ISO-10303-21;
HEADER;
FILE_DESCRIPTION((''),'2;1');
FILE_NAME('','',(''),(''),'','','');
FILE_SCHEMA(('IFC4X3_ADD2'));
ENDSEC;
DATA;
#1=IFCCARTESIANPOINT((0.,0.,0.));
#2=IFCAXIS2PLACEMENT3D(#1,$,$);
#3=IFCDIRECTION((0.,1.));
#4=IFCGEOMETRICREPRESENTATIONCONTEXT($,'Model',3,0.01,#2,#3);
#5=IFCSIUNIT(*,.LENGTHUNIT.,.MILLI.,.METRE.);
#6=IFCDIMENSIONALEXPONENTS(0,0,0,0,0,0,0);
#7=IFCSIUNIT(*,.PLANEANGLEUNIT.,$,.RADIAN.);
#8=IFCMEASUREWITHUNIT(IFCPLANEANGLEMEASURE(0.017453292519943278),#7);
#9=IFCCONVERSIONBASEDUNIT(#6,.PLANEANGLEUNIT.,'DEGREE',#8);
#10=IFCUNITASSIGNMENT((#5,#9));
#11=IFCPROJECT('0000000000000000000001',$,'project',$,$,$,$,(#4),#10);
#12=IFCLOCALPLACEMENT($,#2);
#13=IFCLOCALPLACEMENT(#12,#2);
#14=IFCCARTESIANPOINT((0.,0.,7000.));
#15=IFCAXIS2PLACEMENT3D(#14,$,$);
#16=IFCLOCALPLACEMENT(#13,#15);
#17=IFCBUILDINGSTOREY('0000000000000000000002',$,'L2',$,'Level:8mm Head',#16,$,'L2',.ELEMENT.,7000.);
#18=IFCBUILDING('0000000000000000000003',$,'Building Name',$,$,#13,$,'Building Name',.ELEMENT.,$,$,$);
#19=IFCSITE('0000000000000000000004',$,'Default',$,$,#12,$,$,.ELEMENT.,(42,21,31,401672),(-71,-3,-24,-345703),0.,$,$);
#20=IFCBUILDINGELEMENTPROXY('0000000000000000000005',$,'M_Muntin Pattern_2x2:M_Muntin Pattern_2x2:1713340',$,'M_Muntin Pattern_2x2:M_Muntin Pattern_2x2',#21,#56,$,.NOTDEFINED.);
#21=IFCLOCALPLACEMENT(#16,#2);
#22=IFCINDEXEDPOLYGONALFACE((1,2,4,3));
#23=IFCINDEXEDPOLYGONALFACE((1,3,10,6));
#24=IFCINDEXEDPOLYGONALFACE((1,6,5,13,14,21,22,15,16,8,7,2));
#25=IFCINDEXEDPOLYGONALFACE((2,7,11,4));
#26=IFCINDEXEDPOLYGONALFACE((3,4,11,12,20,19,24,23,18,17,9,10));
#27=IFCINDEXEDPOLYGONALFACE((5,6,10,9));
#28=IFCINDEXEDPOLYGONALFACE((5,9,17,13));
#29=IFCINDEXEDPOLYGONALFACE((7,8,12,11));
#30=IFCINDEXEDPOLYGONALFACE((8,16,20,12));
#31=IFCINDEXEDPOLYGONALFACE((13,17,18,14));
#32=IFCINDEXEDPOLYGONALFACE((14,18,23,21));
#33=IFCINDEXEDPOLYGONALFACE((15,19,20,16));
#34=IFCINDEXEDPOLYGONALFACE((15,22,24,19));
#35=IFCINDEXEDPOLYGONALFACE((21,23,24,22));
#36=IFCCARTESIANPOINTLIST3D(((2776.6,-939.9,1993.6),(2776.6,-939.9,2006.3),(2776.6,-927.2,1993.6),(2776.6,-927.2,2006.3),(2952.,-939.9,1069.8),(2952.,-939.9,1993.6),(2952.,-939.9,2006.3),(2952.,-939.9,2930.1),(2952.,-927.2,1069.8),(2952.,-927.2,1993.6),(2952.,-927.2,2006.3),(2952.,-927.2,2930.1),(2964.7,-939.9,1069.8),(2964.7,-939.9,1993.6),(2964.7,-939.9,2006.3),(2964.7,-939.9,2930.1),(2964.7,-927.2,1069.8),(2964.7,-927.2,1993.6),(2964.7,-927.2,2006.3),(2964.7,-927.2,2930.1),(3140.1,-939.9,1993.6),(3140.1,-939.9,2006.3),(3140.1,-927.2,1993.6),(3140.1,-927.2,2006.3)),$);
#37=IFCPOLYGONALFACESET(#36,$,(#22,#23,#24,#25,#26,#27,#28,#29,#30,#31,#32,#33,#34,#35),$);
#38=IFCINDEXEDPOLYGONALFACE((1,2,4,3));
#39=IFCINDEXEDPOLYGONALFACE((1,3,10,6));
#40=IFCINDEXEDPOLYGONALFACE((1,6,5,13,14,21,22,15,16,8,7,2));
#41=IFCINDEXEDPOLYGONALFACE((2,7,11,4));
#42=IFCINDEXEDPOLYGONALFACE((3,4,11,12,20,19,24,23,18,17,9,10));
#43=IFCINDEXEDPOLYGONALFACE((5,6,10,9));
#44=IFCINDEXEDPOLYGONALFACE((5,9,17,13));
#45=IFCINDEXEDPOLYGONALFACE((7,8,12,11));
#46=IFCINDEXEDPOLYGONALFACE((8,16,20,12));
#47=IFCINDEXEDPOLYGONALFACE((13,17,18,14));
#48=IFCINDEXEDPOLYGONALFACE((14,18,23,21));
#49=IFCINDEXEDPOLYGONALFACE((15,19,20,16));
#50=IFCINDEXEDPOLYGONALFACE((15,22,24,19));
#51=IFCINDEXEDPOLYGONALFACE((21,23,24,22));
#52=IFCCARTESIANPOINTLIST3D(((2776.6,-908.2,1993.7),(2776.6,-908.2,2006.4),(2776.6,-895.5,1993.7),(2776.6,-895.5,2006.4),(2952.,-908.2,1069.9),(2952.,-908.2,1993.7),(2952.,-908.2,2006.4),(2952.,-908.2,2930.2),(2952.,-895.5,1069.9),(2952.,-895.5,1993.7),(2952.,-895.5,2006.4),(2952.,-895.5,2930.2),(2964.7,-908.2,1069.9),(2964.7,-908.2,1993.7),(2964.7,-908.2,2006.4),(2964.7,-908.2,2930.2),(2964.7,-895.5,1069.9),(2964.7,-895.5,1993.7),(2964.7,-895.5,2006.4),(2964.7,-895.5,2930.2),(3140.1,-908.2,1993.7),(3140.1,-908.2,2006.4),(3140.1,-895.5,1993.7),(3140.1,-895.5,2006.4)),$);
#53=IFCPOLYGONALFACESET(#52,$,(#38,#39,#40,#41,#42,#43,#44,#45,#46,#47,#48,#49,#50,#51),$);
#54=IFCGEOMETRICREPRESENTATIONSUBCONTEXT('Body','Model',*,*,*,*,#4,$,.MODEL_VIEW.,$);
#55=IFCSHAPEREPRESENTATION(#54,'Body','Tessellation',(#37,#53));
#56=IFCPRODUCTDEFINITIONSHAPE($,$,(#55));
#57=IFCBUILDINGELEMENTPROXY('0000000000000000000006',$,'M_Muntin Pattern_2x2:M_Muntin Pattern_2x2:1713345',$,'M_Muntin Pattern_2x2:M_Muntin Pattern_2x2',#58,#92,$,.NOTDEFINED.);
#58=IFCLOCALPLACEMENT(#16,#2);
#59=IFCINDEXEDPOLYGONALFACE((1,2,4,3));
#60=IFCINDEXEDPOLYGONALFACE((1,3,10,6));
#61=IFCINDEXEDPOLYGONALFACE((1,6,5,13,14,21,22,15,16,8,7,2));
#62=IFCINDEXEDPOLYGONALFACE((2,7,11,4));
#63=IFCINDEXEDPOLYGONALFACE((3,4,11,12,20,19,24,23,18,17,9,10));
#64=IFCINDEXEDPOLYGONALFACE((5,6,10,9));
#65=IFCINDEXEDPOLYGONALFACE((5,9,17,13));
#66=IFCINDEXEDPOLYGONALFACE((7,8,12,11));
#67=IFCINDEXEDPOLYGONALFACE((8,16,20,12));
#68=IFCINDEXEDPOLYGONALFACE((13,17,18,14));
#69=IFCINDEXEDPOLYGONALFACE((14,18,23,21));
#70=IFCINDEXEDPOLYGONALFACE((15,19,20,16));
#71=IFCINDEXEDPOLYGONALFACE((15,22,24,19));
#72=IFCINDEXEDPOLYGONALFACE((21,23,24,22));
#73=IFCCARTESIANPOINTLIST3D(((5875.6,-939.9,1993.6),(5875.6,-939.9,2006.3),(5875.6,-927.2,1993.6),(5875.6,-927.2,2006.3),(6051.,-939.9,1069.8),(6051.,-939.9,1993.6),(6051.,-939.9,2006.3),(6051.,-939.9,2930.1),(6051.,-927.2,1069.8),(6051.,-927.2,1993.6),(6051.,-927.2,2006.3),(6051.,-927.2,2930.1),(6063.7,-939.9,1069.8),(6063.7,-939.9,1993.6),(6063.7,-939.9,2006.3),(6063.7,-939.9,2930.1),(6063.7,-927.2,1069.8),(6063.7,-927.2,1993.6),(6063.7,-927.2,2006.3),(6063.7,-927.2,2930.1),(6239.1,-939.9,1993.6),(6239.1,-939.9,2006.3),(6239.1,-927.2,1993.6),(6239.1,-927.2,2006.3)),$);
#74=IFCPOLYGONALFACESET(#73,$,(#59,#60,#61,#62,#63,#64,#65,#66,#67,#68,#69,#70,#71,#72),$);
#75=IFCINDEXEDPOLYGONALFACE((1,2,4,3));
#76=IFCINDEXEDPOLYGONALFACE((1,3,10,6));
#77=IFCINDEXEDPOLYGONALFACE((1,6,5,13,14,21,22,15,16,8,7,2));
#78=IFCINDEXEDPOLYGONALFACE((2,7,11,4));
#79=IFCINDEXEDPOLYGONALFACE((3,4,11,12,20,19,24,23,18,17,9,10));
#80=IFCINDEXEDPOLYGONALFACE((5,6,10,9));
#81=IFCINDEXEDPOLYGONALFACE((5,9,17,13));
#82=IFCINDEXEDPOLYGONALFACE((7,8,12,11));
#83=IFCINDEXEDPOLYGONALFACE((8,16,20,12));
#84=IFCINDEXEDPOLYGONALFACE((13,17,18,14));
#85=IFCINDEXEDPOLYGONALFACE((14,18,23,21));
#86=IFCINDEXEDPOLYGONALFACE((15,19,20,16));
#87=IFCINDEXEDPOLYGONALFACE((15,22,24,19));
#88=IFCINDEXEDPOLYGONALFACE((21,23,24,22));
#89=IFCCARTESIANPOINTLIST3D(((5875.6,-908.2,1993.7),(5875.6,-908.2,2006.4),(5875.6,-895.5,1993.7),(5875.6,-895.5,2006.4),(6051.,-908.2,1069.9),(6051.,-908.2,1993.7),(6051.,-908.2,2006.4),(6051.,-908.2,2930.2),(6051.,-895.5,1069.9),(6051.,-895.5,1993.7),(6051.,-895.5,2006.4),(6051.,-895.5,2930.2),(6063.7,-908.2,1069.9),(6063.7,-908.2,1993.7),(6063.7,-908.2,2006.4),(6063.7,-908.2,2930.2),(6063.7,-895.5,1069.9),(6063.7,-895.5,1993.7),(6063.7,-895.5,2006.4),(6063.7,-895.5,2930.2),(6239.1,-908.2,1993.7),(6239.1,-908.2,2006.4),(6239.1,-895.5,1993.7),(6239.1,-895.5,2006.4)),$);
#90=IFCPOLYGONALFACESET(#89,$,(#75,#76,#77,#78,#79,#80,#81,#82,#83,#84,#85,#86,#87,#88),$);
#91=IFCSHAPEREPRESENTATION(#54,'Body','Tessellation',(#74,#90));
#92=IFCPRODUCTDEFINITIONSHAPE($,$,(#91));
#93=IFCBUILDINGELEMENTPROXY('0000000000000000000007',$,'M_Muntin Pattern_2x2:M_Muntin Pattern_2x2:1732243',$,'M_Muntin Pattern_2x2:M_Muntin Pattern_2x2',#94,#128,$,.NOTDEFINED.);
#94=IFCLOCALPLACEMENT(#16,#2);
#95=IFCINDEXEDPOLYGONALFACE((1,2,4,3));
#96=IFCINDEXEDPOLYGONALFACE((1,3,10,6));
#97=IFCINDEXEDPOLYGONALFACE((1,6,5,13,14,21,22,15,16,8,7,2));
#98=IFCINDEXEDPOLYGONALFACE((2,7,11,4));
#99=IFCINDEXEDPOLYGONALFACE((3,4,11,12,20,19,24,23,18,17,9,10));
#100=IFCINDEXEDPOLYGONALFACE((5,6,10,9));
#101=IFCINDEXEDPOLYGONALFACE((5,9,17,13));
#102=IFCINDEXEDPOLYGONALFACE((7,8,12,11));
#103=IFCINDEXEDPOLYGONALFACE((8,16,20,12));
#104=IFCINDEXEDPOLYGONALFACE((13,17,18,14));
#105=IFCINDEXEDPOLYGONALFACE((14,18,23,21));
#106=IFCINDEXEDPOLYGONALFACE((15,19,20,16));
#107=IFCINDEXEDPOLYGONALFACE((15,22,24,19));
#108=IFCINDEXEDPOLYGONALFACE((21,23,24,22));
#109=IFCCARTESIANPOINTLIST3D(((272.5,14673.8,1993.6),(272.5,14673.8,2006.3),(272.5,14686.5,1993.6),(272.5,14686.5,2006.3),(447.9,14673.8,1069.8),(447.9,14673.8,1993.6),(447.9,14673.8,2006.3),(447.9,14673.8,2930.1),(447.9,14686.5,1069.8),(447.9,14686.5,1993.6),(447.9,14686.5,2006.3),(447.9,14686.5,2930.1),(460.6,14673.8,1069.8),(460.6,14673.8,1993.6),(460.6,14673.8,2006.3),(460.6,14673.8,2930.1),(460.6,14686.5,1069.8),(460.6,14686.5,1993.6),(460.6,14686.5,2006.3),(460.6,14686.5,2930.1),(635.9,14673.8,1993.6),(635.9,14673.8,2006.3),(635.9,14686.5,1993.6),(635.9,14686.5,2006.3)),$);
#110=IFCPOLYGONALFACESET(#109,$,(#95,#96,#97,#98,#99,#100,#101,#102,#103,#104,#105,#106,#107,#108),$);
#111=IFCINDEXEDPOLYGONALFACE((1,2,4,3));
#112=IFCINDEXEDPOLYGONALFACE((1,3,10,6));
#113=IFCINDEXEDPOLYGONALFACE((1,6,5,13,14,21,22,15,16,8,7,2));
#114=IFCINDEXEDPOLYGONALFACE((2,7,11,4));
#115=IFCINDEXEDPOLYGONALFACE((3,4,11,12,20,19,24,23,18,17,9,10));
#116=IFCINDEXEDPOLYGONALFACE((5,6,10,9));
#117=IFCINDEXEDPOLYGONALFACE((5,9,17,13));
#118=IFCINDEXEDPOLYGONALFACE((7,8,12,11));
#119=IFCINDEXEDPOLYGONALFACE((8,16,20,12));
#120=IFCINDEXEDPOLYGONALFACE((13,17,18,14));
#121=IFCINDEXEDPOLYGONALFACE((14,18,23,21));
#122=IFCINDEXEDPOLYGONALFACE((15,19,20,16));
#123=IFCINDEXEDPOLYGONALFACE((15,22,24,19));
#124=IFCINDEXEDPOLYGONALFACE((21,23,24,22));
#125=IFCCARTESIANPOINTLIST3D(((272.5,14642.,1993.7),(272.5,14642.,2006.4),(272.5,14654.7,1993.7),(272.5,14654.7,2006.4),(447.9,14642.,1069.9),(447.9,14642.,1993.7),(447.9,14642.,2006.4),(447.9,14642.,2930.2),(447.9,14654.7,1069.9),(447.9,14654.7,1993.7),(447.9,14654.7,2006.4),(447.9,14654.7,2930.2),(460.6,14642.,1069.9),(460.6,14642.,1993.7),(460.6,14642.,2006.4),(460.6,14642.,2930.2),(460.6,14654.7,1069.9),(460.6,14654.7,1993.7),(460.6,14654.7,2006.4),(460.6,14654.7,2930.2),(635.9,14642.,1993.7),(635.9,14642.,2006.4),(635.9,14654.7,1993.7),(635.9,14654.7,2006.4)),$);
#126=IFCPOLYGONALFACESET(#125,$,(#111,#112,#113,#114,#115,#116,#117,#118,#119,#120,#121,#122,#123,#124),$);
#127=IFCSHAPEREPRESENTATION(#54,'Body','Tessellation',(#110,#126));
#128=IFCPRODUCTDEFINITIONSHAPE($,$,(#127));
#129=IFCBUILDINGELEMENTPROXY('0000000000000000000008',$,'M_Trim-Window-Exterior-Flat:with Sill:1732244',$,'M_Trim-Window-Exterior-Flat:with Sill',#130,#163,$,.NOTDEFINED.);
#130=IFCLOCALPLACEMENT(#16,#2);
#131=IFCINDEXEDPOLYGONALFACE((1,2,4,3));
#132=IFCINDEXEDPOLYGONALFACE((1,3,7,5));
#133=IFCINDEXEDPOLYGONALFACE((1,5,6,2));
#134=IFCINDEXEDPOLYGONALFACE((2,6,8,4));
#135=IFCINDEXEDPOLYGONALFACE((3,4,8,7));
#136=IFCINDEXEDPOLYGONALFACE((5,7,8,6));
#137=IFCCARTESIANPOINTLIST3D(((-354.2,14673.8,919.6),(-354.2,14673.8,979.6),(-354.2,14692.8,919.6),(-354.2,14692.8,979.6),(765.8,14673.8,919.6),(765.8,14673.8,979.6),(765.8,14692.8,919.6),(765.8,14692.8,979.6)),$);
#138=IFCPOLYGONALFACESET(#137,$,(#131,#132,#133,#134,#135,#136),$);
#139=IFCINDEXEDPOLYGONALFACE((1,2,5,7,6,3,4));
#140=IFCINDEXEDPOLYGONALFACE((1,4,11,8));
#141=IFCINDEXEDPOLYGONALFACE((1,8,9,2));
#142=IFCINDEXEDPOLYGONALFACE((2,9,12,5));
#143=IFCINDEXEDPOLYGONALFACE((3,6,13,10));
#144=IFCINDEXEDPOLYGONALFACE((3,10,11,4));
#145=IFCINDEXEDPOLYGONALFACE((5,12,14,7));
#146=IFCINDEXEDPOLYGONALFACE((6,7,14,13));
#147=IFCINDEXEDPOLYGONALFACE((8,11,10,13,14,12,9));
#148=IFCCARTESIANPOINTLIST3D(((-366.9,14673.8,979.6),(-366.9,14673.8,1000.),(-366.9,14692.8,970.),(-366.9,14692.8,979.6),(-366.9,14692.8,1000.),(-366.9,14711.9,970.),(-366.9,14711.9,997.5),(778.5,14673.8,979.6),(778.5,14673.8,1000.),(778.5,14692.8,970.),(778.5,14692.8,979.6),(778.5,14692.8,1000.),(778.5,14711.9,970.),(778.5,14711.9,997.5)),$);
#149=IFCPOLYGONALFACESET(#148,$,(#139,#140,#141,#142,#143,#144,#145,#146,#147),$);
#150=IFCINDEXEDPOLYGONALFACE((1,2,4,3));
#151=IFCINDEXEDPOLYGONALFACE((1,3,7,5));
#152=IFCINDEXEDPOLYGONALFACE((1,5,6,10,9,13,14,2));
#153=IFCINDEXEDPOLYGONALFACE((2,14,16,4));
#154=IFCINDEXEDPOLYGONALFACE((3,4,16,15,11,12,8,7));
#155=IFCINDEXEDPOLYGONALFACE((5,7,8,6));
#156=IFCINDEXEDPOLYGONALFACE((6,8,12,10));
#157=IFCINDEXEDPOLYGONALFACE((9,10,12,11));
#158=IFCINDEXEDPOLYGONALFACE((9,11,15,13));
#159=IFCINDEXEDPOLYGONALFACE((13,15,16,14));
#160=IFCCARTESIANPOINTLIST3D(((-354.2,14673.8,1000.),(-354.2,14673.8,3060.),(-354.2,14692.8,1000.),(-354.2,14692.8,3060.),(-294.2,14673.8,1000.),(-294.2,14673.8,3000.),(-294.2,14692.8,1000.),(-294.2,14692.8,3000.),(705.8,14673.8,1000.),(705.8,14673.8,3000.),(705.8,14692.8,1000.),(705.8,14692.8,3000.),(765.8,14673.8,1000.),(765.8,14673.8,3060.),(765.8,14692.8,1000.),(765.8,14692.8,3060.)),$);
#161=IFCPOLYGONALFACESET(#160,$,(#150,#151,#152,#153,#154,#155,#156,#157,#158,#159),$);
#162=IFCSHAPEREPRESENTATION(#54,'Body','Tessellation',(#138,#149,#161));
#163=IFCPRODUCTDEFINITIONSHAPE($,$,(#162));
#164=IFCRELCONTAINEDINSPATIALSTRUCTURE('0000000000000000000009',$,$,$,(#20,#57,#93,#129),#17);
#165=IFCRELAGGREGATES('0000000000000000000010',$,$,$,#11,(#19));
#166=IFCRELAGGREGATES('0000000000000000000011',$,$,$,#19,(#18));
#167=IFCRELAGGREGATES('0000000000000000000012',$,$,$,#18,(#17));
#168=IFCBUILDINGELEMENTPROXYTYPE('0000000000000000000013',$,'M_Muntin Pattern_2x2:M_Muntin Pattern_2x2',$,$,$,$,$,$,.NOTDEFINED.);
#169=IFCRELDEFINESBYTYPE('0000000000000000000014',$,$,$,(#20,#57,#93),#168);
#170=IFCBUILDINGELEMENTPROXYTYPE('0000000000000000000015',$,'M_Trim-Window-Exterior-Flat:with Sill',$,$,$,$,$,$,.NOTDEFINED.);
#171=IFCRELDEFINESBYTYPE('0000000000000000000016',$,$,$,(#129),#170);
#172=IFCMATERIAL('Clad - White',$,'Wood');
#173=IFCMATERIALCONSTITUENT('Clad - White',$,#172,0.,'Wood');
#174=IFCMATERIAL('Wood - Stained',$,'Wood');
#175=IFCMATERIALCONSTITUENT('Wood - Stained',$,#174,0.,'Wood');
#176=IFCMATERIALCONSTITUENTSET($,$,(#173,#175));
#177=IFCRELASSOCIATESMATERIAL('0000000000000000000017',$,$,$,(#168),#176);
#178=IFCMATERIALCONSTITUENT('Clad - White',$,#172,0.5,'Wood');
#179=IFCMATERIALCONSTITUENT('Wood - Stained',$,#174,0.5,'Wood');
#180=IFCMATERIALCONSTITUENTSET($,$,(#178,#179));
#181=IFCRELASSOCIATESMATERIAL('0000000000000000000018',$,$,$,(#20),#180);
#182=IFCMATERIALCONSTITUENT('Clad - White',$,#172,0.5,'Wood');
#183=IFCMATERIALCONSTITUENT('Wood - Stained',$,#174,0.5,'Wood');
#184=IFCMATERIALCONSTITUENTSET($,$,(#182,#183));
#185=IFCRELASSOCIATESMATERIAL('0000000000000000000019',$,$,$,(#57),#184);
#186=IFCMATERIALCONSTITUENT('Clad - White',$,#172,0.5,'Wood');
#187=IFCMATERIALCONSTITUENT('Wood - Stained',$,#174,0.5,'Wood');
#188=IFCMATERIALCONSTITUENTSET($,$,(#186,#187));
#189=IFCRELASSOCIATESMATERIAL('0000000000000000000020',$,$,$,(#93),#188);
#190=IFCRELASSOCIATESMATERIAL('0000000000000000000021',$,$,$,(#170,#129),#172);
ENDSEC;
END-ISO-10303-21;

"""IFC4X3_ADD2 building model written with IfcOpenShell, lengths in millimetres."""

from ifc_helpers import new_model, entity, si_unit, converted_unit, direction, frame, frame_2d, origin, place, context, subcontext, project, spatial, polyline, rectangle, outline, extrude, source, transform, mapped, material, constituent, constituent_set, type_object, type_shapes, element, save


model = new_model("IFC4X3_ADD2")

# Units and contexts
model_context = context("Model", 3, precision=0.01, world=origin(), true_north=direction((0.0, 1.0)))
body_context = subcontext(model_context, "Body", "Model", "MODEL_VIEW")
ifc_project = project(units=[si_unit("LENGTHUNIT", "METRE", prefix="MILLI"), converted_unit("PLANEANGLEUNIT", "DEGREE", entity("IfcPlaneAngleMeasure", 0.017453292519943278), si_unit("PLANEANGLEUNIT", "RADIAN"), dimensions=[0, 0, 0, 0, 0, 0, 0])], contexts=[model_context])

# Site, building, storey
site_placement = place(None, origin())
site = spatial("IfcSite", under=ifc_project, at=site_placement, Name="Default", CompositionType="ELEMENT", RefLatitude=(42, 21, 31, 401672), RefLongitude=(-71, -3, -24, -345703), RefElevation=0.0)
building_placement = place(site_placement, origin())
building = spatial("IfcBuilding", under=site, at=building_placement, Name="Building Name", LongName="Building Name", CompositionType="ELEMENT")
storey_placement = place(building_placement, frame((0.0, 0.0, 7000.0)))
storey = spatial("IfcBuildingStorey", under=building, at=storey_placement, Name="L2", ObjectType="Level:8mm Head", LongName="L2", CompositionType="ELEMENT", Elevation=7000.0)

# Building element proxies
ifc_material_1 = material(Name="Clad - White", Category="Wood")
ifc_material_2 = material(Name="Wood - Stained", Category="Wood")
ifc_constituent_1 = constituent(ifc_material_1, Name="Clad - White", Category="Wood", fraction=0.5)
ifc_constituent_2 = constituent(ifc_material_2, Name="Wood - Stained", Category="Wood", fraction=0.5)
ifc_constituent_set_1 = constituent_set(constituents=[ifc_constituent_1, ifc_constituent_2])
ifc_constituent_3 = constituent(ifc_material_1, Name="Clad - White", Category="Wood", fraction=0.0)
ifc_constituent_4 = constituent(ifc_material_2, Name="Wood - Stained", Category="Wood", fraction=0.0)
ifc_constituent_set_2 = constituent_set(constituents=[ifc_constituent_3, ifc_constituent_4])
building_element_proxy_type_1 = type_object("IfcBuildingElementProxyType", Name="M_Muntin Pattern_2x2:M_Muntin Pattern_2x2", PredefinedType="NOTDEFINED", material=ifc_constituent_set_2)
shared_shape_1 = source(origin(), body_context, "Body", "SweptSolid", [
    extrude(outline(polyline([(6.4, -6.4), (930.1, -6.4), (930.1, 6.3), (6.4, 6.3), (6.4, 181.7), (-6.3, 181.7), (-6.3, 6.3), (-930.2, 6.3), (-930.2, -6.4), (-6.3, -6.4), (-6.3, -181.7), (6.4, -181.7), (6.4, -6.4)])), frame((0.0, -22.2, 930.1), z_axis=(0.0, 1.0, 0.0), x_axis=(0.0, 0.0, 1.0)), (0.0, 0.0, 1.0), 12.7),
    extrude(outline(polyline([(6.4, -6.4), (930.2, -6.4), (930.2, 6.3), (6.4, 6.3), (6.4, 181.7), (-6.3, 181.7), (-6.3, 6.3), (-930.2, 6.3), (-930.2, -6.4), (-6.3, -6.4), (-6.3, -181.7), (6.4, -181.7), (6.4, -6.4)])), frame((0.0, 9.5, 930.2), z_axis=(0.0, 1.0, 0.0), x_axis=(0.0, 0.0, 1.0)), (0.0, 0.0, 1.0), 12.7),
])
type_shapes(building_element_proxy_type_1, [shared_shape_1])
proxy_1_placement = place(storey_placement, frame((2958.4, -917.7, 1069.9)))
element("IfcBuildingElementProxy", 1, at=proxy_1_placement, inside=storey, type_object=building_element_proxy_type_1, material=ifc_constituent_set_1, Name="M_Muntin Pattern_2x2:M_Muntin Pattern_2x2:1713340", ObjectType="M_Muntin Pattern_2x2:M_Muntin Pattern_2x2", PredefinedType="NOTDEFINED", context=body_context, shape_type="MappedRepresentation", body=[
    mapped(shared_shape_1, transform((0.0, 0.0, 0.0), scale=1.0)),
])
ifc_constituent_5 = constituent(ifc_material_1, Name="Clad - White", Category="Wood", fraction=0.5)
ifc_constituent_6 = constituent(ifc_material_2, Name="Wood - Stained", Category="Wood", fraction=0.5)
ifc_constituent_set_3 = constituent_set(constituents=[ifc_constituent_5, ifc_constituent_6])
proxy_2_placement = place(storey_placement, frame((6057.4, -917.7, 1069.9)))
element("IfcBuildingElementProxy", 2, at=proxy_2_placement, inside=storey, type_object=building_element_proxy_type_1, material=ifc_constituent_set_3, Name="M_Muntin Pattern_2x2:M_Muntin Pattern_2x2:1713345", ObjectType="M_Muntin Pattern_2x2:M_Muntin Pattern_2x2", PredefinedType="NOTDEFINED", context=body_context, shape_type="MappedRepresentation", body=[
    mapped(shared_shape_1, transform((0.0, 0.0, 0.0), scale=1.0)),
])
ifc_constituent_7 = constituent(ifc_material_1, Name="Clad - White", Category="Wood", fraction=0.5)
ifc_constituent_8 = constituent(ifc_material_2, Name="Wood - Stained", Category="Wood", fraction=0.5)
ifc_constituent_set_4 = constituent_set(constituents=[ifc_constituent_7, ifc_constituent_8])
proxy_3_placement = place(storey_placement, frame((454.2, 14664.3, 1069.9), z_axis=(0.0, 0.0, 1.0), x_axis=(-1.0, 0.0, 0.0)))
element("IfcBuildingElementProxy", 3, at=proxy_3_placement, inside=storey, type_object=building_element_proxy_type_1, material=ifc_constituent_set_4, Name="M_Muntin Pattern_2x2:M_Muntin Pattern_2x2:1732243", ObjectType="M_Muntin Pattern_2x2:M_Muntin Pattern_2x2", PredefinedType="NOTDEFINED", context=body_context, shape_type="MappedRepresentation", body=[
    mapped(shared_shape_1, transform((0.0, 0.0, 0.0), scale=1.0)),
])
building_element_proxy_type_2 = type_object("IfcBuildingElementProxyType", Name="M_Trim-Window-Exterior-Flat:with Sill", PredefinedType="NOTDEFINED", material=ifc_material_1)
shared_shape_2 = source(origin(), body_context, "Body", "SweptSolid", [
    extrude(rectangle(XDim=1120.0, YDim=60.0, at=frame_2d((0.0, 0.0), x_axis=(1.0, 0.0))), frame((0.0, -2050.4, 0.0), z_axis=(0.0, 0.0, 1.0), x_axis=(-1.0, 0.0, 0.0)), (0.0, 0.0, 1.0), 19.0),
    extrude(outline(polyline([(-19.0, -15.2), (0.0, -15.2), (0.0, -5.7), (19.0, -5.7), (19.0, 14.8), (0.0, 14.8), (-19.0, 12.3), (-19.0, -15.2)])), frame((-572.7, -2014.8, 19.0), z_axis=(1.0, 0.0, 0.0), x_axis=(0.0, 0.0, -1.0)), (0.0, 0.0, 1.0), 1145.4),
    extrude(outline(polyline([(-1045.0, -560.0), (1015.0, -560.0), (1015.0, -500.0), (-985.0, -500.0), (-985.0, 500.0), (1015.0, 500.0), (1015.0, 560.0), (-1045.0, 560.0), (-1045.0, -560.0)])), frame((0.0, -985.0, 0.0), z_axis=(0.0, 0.0, 1.0), x_axis=(0.0, -1.0, 0.0)), (0.0, 0.0, 1.0), 19.0),
])
type_shapes(building_element_proxy_type_2, [shared_shape_2])
proxy_4_placement = place(storey_placement, frame((205.8, 14673.8, 3000.0), z_axis=(0.0, 1.0, 0.0), x_axis=(-1.0, 0.0, 0.0)))
element("IfcBuildingElementProxy", 4, at=proxy_4_placement, inside=storey, type_object=building_element_proxy_type_2, material=ifc_material_1, Name="M_Trim-Window-Exterior-Flat:with Sill:1732244", ObjectType="M_Trim-Window-Exterior-Flat:with Sill", PredefinedType="NOTDEFINED", context=body_context, shape_type="MappedRepresentation", body=[
    mapped(shared_shape_2, transform((0.0, 0.0, 0.0), scale=1.0)),
])

save(model, "model.ifc")
